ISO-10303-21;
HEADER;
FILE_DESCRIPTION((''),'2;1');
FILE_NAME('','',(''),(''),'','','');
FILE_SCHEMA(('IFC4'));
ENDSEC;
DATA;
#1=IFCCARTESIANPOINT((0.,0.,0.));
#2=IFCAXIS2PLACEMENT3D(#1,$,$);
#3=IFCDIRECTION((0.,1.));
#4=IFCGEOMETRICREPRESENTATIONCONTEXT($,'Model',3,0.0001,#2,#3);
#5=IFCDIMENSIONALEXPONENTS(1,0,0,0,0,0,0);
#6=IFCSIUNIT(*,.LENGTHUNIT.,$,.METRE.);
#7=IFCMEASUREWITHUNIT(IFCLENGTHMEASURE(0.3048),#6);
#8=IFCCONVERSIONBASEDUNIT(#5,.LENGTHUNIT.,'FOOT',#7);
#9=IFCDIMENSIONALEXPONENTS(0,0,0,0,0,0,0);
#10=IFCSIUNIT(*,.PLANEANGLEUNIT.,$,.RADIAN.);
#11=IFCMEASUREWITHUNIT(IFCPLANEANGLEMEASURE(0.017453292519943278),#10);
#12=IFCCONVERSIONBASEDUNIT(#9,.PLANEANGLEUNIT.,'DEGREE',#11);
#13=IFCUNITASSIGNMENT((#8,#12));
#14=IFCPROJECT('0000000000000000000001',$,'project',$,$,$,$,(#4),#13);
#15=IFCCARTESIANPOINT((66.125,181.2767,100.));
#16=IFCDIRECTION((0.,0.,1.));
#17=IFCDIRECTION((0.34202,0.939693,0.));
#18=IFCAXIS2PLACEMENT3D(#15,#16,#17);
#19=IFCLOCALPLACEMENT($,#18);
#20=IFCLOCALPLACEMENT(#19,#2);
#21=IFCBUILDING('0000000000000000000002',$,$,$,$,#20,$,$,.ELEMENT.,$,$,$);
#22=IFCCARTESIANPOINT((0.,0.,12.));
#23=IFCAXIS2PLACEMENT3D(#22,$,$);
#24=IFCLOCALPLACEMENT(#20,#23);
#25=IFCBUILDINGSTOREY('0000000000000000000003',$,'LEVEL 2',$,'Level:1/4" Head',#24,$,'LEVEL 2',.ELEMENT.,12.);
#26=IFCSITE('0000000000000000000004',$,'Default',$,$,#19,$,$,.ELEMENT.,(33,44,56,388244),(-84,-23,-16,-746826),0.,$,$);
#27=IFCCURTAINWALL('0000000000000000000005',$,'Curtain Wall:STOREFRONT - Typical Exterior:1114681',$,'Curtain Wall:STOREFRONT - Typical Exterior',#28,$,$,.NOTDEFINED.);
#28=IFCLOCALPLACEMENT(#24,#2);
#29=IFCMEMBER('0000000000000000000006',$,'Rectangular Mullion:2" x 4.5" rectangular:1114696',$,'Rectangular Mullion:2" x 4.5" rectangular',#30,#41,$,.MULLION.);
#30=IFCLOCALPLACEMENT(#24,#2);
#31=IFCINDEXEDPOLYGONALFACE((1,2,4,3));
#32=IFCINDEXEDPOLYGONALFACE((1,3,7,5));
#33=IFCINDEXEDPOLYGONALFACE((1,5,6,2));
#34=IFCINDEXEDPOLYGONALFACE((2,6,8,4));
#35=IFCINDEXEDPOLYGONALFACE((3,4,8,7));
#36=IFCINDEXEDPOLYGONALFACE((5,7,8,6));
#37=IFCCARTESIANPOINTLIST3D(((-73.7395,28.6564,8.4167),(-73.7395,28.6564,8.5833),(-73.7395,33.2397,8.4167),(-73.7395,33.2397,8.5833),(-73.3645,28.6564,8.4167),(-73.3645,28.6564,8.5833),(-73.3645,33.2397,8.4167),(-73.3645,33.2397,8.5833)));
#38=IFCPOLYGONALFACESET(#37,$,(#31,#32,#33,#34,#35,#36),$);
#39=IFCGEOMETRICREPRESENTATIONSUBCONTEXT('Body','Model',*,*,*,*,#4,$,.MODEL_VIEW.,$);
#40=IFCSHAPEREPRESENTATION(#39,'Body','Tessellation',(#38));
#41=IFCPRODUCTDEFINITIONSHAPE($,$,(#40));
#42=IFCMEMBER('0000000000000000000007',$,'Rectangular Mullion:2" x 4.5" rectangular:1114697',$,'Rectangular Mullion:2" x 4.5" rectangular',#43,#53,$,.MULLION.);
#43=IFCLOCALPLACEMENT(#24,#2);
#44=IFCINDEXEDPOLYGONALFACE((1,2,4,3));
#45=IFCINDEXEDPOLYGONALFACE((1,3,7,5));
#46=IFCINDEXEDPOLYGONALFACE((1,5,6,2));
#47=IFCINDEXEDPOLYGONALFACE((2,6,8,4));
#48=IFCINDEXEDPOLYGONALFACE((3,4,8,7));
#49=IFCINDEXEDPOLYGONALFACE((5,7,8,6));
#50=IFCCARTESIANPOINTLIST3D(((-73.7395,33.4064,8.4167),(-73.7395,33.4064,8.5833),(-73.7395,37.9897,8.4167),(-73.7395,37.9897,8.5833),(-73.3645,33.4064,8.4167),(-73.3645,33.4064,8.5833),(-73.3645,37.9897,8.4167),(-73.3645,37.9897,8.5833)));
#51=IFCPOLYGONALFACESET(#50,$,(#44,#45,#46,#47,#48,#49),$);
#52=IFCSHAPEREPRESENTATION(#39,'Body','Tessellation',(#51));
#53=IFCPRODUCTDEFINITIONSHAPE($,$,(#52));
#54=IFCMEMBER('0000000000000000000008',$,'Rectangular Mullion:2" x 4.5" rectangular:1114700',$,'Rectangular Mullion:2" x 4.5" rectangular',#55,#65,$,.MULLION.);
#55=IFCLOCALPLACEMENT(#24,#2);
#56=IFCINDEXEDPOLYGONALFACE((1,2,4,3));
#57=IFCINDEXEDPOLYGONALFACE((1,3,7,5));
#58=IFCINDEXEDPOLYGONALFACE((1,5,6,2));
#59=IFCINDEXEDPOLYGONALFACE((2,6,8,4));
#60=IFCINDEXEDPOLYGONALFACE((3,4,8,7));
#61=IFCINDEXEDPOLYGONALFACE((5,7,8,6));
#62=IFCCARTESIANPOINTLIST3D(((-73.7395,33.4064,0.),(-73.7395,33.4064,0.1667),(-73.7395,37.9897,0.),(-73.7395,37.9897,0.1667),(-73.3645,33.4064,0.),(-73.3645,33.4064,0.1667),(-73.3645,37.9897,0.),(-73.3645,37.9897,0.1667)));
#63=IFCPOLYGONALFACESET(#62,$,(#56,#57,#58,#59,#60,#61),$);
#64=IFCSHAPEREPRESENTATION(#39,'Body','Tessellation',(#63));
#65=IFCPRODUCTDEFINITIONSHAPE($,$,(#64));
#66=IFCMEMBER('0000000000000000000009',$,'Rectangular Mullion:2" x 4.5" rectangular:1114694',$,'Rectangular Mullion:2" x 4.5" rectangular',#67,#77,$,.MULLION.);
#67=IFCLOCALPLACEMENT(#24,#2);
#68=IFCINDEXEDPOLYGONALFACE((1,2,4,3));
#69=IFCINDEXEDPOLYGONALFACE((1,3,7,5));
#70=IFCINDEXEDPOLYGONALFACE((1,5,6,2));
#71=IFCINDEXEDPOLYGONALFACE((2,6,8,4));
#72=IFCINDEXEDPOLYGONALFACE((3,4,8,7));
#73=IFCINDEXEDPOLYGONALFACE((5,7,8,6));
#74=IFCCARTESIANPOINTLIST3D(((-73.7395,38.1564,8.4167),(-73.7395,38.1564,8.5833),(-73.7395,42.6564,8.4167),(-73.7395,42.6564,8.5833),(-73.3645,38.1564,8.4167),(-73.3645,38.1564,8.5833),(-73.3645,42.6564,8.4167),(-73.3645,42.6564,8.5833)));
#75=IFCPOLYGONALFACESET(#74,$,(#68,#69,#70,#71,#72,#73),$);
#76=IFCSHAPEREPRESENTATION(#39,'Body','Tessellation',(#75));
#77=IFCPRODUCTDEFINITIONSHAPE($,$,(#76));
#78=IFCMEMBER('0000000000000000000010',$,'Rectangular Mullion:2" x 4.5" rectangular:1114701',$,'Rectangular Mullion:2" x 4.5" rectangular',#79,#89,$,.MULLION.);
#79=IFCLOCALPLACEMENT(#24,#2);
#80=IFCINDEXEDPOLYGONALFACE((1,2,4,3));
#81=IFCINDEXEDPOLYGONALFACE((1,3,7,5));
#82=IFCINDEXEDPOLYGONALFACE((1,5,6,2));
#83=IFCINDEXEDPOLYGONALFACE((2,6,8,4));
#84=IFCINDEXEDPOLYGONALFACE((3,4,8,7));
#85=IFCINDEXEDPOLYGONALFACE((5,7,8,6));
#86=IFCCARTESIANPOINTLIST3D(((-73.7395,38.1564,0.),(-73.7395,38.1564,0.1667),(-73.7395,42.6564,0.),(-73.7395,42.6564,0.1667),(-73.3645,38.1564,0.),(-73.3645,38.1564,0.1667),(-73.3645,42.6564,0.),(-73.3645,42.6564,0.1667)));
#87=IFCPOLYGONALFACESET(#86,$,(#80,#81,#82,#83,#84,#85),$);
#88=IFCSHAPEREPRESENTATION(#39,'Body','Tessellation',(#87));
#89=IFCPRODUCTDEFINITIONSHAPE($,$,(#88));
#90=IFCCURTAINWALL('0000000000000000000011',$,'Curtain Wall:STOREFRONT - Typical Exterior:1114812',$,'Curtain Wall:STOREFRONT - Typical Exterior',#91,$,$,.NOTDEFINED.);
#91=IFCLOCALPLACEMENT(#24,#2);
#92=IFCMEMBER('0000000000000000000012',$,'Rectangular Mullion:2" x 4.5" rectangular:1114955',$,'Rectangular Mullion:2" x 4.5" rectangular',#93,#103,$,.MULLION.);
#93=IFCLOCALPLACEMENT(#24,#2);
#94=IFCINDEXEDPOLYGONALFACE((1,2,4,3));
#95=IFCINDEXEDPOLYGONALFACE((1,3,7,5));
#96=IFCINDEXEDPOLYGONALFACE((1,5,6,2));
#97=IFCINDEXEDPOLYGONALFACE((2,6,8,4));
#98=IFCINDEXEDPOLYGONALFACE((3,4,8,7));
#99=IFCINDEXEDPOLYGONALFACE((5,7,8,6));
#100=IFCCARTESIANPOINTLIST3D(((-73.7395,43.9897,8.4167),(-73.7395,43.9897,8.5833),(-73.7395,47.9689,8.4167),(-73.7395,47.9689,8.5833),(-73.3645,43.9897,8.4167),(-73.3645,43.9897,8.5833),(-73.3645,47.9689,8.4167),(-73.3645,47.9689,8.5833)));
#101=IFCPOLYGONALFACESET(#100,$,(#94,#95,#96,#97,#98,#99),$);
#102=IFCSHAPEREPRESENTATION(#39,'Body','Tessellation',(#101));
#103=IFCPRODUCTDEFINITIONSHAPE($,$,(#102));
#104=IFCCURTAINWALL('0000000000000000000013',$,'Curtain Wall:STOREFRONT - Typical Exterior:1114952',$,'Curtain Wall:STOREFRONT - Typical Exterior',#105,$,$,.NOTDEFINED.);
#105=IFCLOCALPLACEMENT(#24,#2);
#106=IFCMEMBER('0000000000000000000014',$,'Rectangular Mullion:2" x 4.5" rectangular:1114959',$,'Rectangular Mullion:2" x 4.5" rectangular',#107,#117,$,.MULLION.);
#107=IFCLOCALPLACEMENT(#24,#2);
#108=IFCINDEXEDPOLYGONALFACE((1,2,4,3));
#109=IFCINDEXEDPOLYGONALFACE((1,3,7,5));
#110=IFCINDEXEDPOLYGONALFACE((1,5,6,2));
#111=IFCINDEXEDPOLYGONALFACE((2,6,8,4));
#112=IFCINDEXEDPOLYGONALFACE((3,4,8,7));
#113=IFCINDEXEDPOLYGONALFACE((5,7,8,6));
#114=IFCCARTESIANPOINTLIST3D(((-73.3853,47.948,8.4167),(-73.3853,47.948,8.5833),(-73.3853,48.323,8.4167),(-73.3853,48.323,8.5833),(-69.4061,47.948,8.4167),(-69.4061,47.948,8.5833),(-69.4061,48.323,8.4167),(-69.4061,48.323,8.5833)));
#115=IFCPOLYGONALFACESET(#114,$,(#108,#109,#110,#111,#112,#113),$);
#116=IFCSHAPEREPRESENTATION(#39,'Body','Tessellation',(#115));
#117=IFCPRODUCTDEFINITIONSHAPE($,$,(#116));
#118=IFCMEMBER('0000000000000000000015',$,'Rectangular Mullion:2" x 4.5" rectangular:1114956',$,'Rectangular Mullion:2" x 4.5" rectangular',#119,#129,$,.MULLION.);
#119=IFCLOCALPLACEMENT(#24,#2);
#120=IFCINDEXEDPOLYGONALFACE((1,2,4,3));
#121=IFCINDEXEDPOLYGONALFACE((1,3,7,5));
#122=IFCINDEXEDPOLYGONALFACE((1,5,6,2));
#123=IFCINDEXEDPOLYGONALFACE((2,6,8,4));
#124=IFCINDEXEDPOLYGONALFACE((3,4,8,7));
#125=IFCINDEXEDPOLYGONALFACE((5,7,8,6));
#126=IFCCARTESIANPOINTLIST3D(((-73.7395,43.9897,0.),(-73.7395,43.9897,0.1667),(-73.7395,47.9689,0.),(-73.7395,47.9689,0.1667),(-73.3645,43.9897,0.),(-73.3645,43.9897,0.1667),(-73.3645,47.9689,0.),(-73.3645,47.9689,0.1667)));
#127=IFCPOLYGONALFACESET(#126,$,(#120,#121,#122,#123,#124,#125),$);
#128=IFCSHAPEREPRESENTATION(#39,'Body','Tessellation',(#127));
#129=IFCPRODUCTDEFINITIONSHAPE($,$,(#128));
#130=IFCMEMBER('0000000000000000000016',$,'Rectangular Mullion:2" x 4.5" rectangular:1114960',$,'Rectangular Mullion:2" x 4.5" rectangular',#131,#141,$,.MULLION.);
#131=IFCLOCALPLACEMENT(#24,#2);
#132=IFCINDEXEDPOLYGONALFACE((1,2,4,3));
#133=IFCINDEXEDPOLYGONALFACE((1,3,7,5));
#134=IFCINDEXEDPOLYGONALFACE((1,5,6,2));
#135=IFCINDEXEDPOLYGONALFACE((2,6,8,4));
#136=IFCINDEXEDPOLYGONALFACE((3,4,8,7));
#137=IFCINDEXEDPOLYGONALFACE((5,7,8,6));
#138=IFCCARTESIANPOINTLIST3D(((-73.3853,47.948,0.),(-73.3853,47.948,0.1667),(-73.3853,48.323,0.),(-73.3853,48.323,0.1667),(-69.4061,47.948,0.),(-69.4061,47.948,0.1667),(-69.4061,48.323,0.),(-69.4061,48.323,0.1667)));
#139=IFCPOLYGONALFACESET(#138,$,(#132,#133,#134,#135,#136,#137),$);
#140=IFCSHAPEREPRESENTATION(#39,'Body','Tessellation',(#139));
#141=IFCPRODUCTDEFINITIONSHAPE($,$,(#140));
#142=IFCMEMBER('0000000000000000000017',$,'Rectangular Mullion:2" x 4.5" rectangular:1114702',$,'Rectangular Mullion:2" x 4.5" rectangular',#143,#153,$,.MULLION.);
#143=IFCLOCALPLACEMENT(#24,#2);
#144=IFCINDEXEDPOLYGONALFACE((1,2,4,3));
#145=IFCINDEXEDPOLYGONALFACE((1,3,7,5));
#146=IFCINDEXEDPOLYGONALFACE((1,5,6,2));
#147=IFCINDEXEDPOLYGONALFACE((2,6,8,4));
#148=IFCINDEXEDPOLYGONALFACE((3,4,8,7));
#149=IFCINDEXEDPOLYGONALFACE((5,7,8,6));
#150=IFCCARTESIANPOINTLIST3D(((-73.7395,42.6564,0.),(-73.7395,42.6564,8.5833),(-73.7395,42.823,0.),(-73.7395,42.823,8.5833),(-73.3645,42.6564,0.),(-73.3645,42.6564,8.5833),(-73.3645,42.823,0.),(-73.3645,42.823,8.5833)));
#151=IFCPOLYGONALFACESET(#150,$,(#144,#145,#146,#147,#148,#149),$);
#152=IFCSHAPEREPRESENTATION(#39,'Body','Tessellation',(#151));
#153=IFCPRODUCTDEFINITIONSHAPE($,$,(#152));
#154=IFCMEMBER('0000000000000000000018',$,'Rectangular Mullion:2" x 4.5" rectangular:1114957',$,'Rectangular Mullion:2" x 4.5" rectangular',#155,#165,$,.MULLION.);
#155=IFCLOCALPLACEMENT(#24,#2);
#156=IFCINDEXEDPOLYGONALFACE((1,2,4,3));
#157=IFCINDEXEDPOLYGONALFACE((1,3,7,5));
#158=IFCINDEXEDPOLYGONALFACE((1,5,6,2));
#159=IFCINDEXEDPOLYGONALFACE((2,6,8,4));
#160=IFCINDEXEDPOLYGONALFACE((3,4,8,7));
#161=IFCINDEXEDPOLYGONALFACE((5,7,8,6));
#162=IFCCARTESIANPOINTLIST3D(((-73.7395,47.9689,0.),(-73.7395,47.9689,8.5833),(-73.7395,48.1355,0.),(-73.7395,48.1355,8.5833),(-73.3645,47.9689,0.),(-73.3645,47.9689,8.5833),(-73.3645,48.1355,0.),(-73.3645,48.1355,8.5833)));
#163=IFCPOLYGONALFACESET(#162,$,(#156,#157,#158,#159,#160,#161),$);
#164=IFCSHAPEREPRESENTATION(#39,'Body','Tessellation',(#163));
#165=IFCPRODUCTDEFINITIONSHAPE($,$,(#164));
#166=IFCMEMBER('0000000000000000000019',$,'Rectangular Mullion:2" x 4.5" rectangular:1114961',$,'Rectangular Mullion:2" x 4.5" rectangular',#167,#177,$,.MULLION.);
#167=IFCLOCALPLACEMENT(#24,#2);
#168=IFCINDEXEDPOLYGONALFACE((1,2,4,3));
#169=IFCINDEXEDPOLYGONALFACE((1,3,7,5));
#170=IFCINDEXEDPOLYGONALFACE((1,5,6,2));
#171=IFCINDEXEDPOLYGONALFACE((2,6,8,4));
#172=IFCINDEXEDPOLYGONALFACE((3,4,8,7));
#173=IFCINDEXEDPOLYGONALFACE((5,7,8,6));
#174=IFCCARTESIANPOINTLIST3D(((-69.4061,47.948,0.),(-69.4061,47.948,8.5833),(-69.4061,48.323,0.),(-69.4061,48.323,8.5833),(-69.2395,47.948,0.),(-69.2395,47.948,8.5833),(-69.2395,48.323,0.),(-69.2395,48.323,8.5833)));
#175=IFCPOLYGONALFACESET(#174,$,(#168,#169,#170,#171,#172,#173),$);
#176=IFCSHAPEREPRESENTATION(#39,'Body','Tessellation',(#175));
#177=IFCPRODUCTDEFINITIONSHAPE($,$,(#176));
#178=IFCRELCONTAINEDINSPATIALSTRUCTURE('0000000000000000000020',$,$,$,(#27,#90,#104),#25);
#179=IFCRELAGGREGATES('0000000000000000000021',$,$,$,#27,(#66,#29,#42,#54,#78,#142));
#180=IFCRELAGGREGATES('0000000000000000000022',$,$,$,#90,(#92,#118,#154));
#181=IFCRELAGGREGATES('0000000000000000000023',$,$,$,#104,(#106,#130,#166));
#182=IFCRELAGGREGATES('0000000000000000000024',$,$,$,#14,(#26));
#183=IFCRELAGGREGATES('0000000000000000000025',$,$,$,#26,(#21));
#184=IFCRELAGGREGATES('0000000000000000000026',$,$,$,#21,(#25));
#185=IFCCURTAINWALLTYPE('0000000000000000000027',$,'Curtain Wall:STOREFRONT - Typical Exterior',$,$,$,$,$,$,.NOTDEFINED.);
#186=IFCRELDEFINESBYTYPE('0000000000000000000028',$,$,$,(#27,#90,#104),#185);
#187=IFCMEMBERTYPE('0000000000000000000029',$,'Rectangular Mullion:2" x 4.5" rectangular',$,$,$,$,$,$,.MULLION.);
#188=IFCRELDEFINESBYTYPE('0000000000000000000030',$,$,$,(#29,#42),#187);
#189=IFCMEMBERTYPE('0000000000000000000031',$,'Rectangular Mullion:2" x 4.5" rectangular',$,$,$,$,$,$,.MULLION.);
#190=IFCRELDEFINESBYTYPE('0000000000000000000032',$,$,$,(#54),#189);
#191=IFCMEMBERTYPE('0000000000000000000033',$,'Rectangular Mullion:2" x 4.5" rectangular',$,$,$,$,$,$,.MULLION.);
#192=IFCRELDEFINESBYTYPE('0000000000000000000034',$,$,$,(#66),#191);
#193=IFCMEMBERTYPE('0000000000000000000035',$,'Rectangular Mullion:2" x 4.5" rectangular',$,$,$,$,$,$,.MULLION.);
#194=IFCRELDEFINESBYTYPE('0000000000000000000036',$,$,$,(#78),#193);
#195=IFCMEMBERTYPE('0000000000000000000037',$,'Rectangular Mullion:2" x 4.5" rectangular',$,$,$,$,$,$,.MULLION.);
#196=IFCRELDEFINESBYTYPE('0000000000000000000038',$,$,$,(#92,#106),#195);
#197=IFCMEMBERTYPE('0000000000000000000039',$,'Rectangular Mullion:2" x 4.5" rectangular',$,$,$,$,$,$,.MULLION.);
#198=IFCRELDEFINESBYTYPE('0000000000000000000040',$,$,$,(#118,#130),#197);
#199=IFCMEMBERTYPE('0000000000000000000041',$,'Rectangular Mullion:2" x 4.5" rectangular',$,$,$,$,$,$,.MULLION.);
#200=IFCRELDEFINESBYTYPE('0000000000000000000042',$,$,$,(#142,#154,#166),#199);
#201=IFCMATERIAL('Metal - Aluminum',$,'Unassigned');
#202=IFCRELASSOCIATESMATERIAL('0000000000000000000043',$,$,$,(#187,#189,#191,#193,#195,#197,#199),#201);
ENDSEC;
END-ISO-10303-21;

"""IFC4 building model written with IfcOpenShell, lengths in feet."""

from ifc_helpers import new_model, entity, si_unit, converted_unit, direction, frame, origin, origin_2d_with_axis, place, context, subcontext, project, spatial, rectangle, extrude, source, transform, mapped, material, material_profile, profile_set, type_object, type_shapes, element, aggregate, save


model = new_model("IFC4")

# Units and contexts
model_context = context("Model", 3, precision=0.0001, world=origin(), true_north=direction((0.0, 1.0)))
body_context = subcontext(model_context, "Body", "Model", "MODEL_VIEW")
ifc_project = project(units=[converted_unit("LENGTHUNIT", "FOOT", entity("IfcLengthMeasure", 0.3048), si_unit("LENGTHUNIT", "METRE"), dimensions=[1, 0, 0, 0, 0, 0, 0]), converted_unit("PLANEANGLEUNIT", "DEGREE", entity("IfcPlaneAngleMeasure", 0.017453292519943278), si_unit("PLANEANGLEUNIT", "RADIAN"), dimensions=[0, 0, 0, 0, 0, 0, 0])], contexts=[model_context])

# Site, building, storey
site_placement = place(None, frame((66.125, 181.2767, 100.0), z_axis=(0.0, 0.0, 1.0), x_axis=(0.34202, 0.939693, 0.0)))
site = spatial("IfcSite", under=ifc_project, at=site_placement, Name="Default", CompositionType="ELEMENT", RefLatitude=(33, 44, 56, 388244), RefLongitude=(-84, -23, -16, -746826), RefElevation=0.0)
building_placement = place(site_placement, origin())
building = spatial("IfcBuilding", under=site, at=building_placement, CompositionType="ELEMENT")
storey_placement = place(building_placement, frame((0.0, 0.0, 12.0)))
storey = spatial("IfcBuildingStorey", under=building, at=storey_placement, Name="LEVEL 2", ObjectType="Level:1/4\" Head", LongName="LEVEL 2", CompositionType="ELEMENT", Elevation=12.0)

# Curtain wall, members
curtain_wall_type = type_object("IfcCurtainWallType", Name="Curtain Wall:STOREFRONT - Typical Exterior", PredefinedType="NOTDEFINED")
curtain_wall_1_placement = place(storey_placement, frame((0.0, 0.0, -12.0)))
curtain_wall_1 = element("IfcCurtainWall", 1, at=curtain_wall_1_placement, inside=storey, type_object=curtain_wall_type, Name="Curtain Wall:STOREFRONT - Typical Exterior:1114681", ObjectType="Curtain Wall:STOREFRONT - Typical Exterior", PredefinedType="NOTDEFINED")
ifc_material_1 = material(Name="Metal - Aluminum", Category="Unassigned")
ifc_material_profile = material_profile(ifc_material_1, rectangle(XDim=0.1667, YDim=0.375, at=origin_2d_with_axis()), Name="2\" x 4.5\" rectangular")
ifc_profile_set = profile_set([ifc_material_profile], Name="2\" x 4.5\" rectangular")
member_type_1 = type_object("IfcMemberType", Name="Rectangular Mullion:2\" x 4.5\" rectangular", PredefinedType="MULLION", material=ifc_profile_set)
shared_shape_1 = source(origin(), body_context, "Body", "SweptSolid", [
    extrude(rectangle(XDim=0.1667, YDim=0.375, at=origin_2d_with_axis()), frame((-0.0833, 0.0, -4.5833), z_axis=(0.0, 0.0, 1.0), x_axis=(-1.0, 0.0, 0.0)), (0.0, 0.0, 1.0), 4.5833),
])
type_shapes(member_type_1, [shared_shape_1])
member_1_placement = place(curtain_wall_1_placement, frame((-73.552, 33.2397, 20.5833), z_axis=(0.0, 1.0, 0.0), x_axis=(0.0, 0.0, 1.0)))
member_1 = element("IfcMember", 2, at=member_1_placement, type_object=member_type_1, Name="Rectangular Mullion:2\" x 4.5\" rectangular:1114696", ObjectType="Rectangular Mullion:2\" x 4.5\" rectangular", PredefinedType="MULLION", context=body_context, shape_type="MappedRepresentation", body=[
    mapped(shared_shape_1, transform((0.0, 0.0, 0.0), scale=1.0)),
])
member_2_placement = place(curtain_wall_1_placement, frame((-73.552, 37.9897, 20.5833), z_axis=(0.0, 1.0, 0.0), x_axis=(0.0, 0.0, 1.0)))
member_2 = element("IfcMember", 3, at=member_2_placement, type_object=member_type_1, Name="Rectangular Mullion:2\" x 4.5\" rectangular:1114697", ObjectType="Rectangular Mullion:2\" x 4.5\" rectangular", PredefinedType="MULLION", context=body_context, shape_type="MappedRepresentation", body=[
    mapped(shared_shape_1, transform((0.0, 0.0, 0.0), scale=1.0)),
])
member_type_2 = type_object("IfcMemberType", Name="Rectangular Mullion:2\" x 4.5\" rectangular", PredefinedType="MULLION", material=ifc_profile_set)
shared_shape_2 = source(origin(), body_context, "Body", "SweptSolid", [
    extrude(rectangle(XDim=0.1667, YDim=0.375, at=origin_2d_with_axis()), frame((-0.0833, 0.0, -4.5833), z_axis=(0.0, 0.0, 1.0), x_axis=(-1.0, 0.0, 0.0)), (0.0, 0.0, 1.0), 4.5833),
])
type_shapes(member_type_2, [shared_shape_2])
member_3_placement = place(curtain_wall_1_placement, frame((-73.552, 33.4064, 12.0), z_axis=(0.0, -1.0, 0.0), x_axis=(0.0, 0.0, -1.0)))
member_3 = element("IfcMember", 4, at=member_3_placement, type_object=member_type_2, Name="Rectangular Mullion:2\" x 4.5\" rectangular:1114700", ObjectType="Rectangular Mullion:2\" x 4.5\" rectangular", PredefinedType="MULLION", context=body_context, shape_type="MappedRepresentation", body=[
    mapped(shared_shape_2, transform((0.0, 0.0, 0.0), scale=1.0)),
])
member_type_3 = type_object("IfcMemberType", Name="Rectangular Mullion:2\" x 4.5\" rectangular", PredefinedType="MULLION", material=ifc_profile_set)
shared_shape_3 = source(origin(), body_context, "Body", "SweptSolid", [
    extrude(rectangle(XDim=0.1667, YDim=0.375, at=origin_2d_with_axis()), frame((-0.0833, 0.0, -4.5), z_axis=(0.0, 0.0, 1.0), x_axis=(-1.0, 0.0, 0.0)), (0.0, 0.0, 1.0), 4.5),
])
type_shapes(member_type_3, [shared_shape_3])
member_4_placement = place(curtain_wall_1_placement, frame((-73.552, 42.6564, 20.5833), z_axis=(0.0, 1.0, 0.0), x_axis=(0.0, 0.0, 1.0)))
member_4 = element("IfcMember", 5, at=member_4_placement, type_object=member_type_3, Name="Rectangular Mullion:2\" x 4.5\" rectangular:1114694", ObjectType="Rectangular Mullion:2\" x 4.5\" rectangular", PredefinedType="MULLION", context=body_context, shape_type="MappedRepresentation", body=[
    mapped(shared_shape_3, transform((0.0, 0.0, 0.0), scale=1.0)),
])
member_type_4 = type_object("IfcMemberType", Name="Rectangular Mullion:2\" x 4.5\" rectangular", PredefinedType="MULLION", material=ifc_profile_set)
shared_shape_4 = source(origin(), body_context, "Body", "SweptSolid", [
    extrude(rectangle(XDim=0.1667, YDim=0.375, at=origin_2d_with_axis()), frame((-0.0833, 0.0, -4.5), z_axis=(0.0, 0.0, 1.0), x_axis=(-1.0, 0.0, 0.0)), (0.0, 0.0, 1.0), 4.5),
])
type_shapes(member_type_4, [shared_shape_4])
member_5_placement = place(curtain_wall_1_placement, frame((-73.552, 38.1564, 12.0), z_axis=(0.0, -1.0, 0.0), x_axis=(0.0, 0.0, -1.0)))
member_5 = element("IfcMember", 6, at=member_5_placement, type_object=member_type_4, Name="Rectangular Mullion:2\" x 4.5\" rectangular:1114701", ObjectType="Rectangular Mullion:2\" x 4.5\" rectangular", PredefinedType="MULLION", context=body_context, shape_type="MappedRepresentation", body=[
    mapped(shared_shape_4, transform((0.0, 0.0, 0.0), scale=1.0)),
])

# Curtain walls, members
curtain_wall_2_placement = place(storey_placement, frame((0.0, 0.0, -12.0)))
curtain_wall_2 = element("IfcCurtainWall", 7, at=curtain_wall_2_placement, inside=storey, type_object=curtain_wall_type, Name="Curtain Wall:STOREFRONT - Typical Exterior:1114812", ObjectType="Curtain Wall:STOREFRONT - Typical Exterior", PredefinedType="NOTDEFINED")
member_type_5 = type_object("IfcMemberType", Name="Rectangular Mullion:2\" x 4.5\" rectangular", PredefinedType="MULLION", material=ifc_profile_set)
shared_shape_5 = source(origin(), body_context, "Body", "SweptSolid", [
    extrude(rectangle(XDim=0.1667, YDim=0.375, at=origin_2d_with_axis()), frame((-0.0833, 0.0, -3.9792), z_axis=(0.0, 0.0, 1.0), x_axis=(-1.0, 0.0, 0.0)), (0.0, 0.0, 1.0), 3.9792),
])
type_shapes(member_type_5, [shared_shape_5])
member_6_placement = place(curtain_wall_2_placement, frame((-73.552, 47.9689, 20.5833), z_axis=(0.0, 1.0, 0.0), x_axis=(0.0, 0.0, 1.0)))
member_6 = element("IfcMember", 8, at=member_6_placement, type_object=member_type_5, Name="Rectangular Mullion:2\" x 4.5\" rectangular:1114955", ObjectType="Rectangular Mullion:2\" x 4.5\" rectangular", PredefinedType="MULLION", context=body_context, shape_type="MappedRepresentation", body=[
    mapped(shared_shape_5, transform((0.0, 0.0, 0.0), scale=1.0)),
])
curtain_wall_3_placement = place(storey_placement, frame((0.0, 0.0, -12.0)))
curtain_wall_3 = element("IfcCurtainWall", 9, at=curtain_wall_3_placement, inside=storey, type_object=curtain_wall_type, Name="Curtain Wall:STOREFRONT - Typical Exterior:1114952", ObjectType="Curtain Wall:STOREFRONT - Typical Exterior", PredefinedType="NOTDEFINED")
member_7_placement = place(curtain_wall_3_placement, frame((-69.4061, 48.1355, 20.5833), z_axis=(1.0, 0.0, 0.0), x_axis=(0.0, 0.0, 1.0)))
member_7 = element("IfcMember", 10, at=member_7_placement, type_object=member_type_5, Name="Rectangular Mullion:2\" x 4.5\" rectangular:1114959", ObjectType="Rectangular Mullion:2\" x 4.5\" rectangular", PredefinedType="MULLION", context=body_context, shape_type="MappedRepresentation", body=[
    mapped(shared_shape_5, transform((0.0, 0.0, 0.0), scale=1.0)),
])

# Members
member_type_6 = type_object("IfcMemberType", Name="Rectangular Mullion:2\" x 4.5\" rectangular", PredefinedType="MULLION", material=ifc_profile_set)
shared_shape_6 = source(origin(), body_context, "Body", "SweptSolid", [
    extrude(rectangle(XDim=0.1667, YDim=0.375, at=origin_2d_with_axis()), frame((-0.0833, 0.0, -3.9792), z_axis=(0.0, 0.0, 1.0), x_axis=(-1.0, 0.0, 0.0)), (0.0, 0.0, 1.0), 3.9792),
])
type_shapes(member_type_6, [shared_shape_6])
member_8_placement = place(curtain_wall_2_placement, frame((-73.552, 43.9897, 12.0), z_axis=(0.0, -1.0, 0.0), x_axis=(0.0, 0.0, -1.0)))
member_8 = element("IfcMember", 11, at=member_8_placement, type_object=member_type_6, Name="Rectangular Mullion:2\" x 4.5\" rectangular:1114956", ObjectType="Rectangular Mullion:2\" x 4.5\" rectangular", PredefinedType="MULLION", context=body_context, shape_type="MappedRepresentation", body=[
    mapped(shared_shape_6, transform((0.0, 0.0, 0.0), scale=1.0)),
])
member_9_placement = place(curtain_wall_3_placement, frame((-73.3853, 48.1355, 12.0), z_axis=(-1.0, 0.0, 0.0), x_axis=(0.0, 0.0, -1.0)))
member_9 = element("IfcMember", 12, at=member_9_placement, type_object=member_type_6, Name="Rectangular Mullion:2\" x 4.5\" rectangular:1114960", ObjectType="Rectangular Mullion:2\" x 4.5\" rectangular", PredefinedType="MULLION", context=body_context, shape_type="MappedRepresentation", body=[
    mapped(shared_shape_6, transform((0.0, 0.0, 0.0), scale=1.0)),
])
member_type_7 = type_object("IfcMemberType", Name="Rectangular Mullion:2\" x 4.5\" rectangular", PredefinedType="MULLION", material=ifc_profile_set)
shared_shape_7 = source(origin(), body_context, "Body", "SweptSolid", [
    extrude(rectangle(XDim=0.1667, YDim=0.375, at=origin_2d_with_axis()), frame((-0.0833, 0.0, -8.5833), z_axis=(0.0, 0.0, 1.0), x_axis=(-1.0, 0.0, 0.0)), (0.0, 0.0, 1.0), 8.5833),
])
type_shapes(member_type_7, [shared_shape_7])
member_10_placement = place(curtain_wall_1_placement, frame((-73.552, 42.823, 12.0), z_axis=(0.0, 0.0, -1.0), x_axis=(0.0, 1.0, 0.0)))
member_10 = element("IfcMember", 13, at=member_10_placement, type_object=member_type_7, Name="Rectangular Mullion:2\" x 4.5\" rectangular:1114702", ObjectType="Rectangular Mullion:2\" x 4.5\" rectangular", PredefinedType="MULLION", context=body_context, shape_type="MappedRepresentation", body=[
    mapped(shared_shape_7, transform((0.0, 0.0, 0.0), scale=1.0)),
])
member_11_placement = place(curtain_wall_2_placement, frame((-73.552, 48.1355, 12.0), z_axis=(0.0, 0.0, -1.0), x_axis=(0.0, 1.0, 0.0)))
member_11 = element("IfcMember", 14, at=member_11_placement, type_object=member_type_7, Name="Rectangular Mullion:2\" x 4.5\" rectangular:1114957", ObjectType="Rectangular Mullion:2\" x 4.5\" rectangular", PredefinedType="MULLION", context=body_context, shape_type="MappedRepresentation", body=[
    mapped(shared_shape_7, transform((0.0, 0.0, 0.0), scale=1.0)),
])
member_12_placement = place(curtain_wall_3_placement, frame((-69.2395, 48.1355, 12.0), z_axis=(0.0, 0.0, -1.0), x_axis=(1.0, 0.0, 0.0)))
member_12 = element("IfcMember", 15, at=member_12_placement, type_object=member_type_7, Name="Rectangular Mullion:2\" x 4.5\" rectangular:1114961", ObjectType="Rectangular Mullion:2\" x 4.5\" rectangular", PredefinedType="MULLION", context=body_context, shape_type="MappedRepresentation", body=[
    mapped(shared_shape_7, transform((0.0, 0.0, 0.0), scale=1.0)),
])

aggregate(curtain_wall_1, [member_4, member_1, member_2, member_3, member_5, member_10])
aggregate(curtain_wall_2, [member_6, member_8, member_11])
aggregate(curtain_wall_3, [member_7, member_9, member_12])

save(model, "model.ifc")
